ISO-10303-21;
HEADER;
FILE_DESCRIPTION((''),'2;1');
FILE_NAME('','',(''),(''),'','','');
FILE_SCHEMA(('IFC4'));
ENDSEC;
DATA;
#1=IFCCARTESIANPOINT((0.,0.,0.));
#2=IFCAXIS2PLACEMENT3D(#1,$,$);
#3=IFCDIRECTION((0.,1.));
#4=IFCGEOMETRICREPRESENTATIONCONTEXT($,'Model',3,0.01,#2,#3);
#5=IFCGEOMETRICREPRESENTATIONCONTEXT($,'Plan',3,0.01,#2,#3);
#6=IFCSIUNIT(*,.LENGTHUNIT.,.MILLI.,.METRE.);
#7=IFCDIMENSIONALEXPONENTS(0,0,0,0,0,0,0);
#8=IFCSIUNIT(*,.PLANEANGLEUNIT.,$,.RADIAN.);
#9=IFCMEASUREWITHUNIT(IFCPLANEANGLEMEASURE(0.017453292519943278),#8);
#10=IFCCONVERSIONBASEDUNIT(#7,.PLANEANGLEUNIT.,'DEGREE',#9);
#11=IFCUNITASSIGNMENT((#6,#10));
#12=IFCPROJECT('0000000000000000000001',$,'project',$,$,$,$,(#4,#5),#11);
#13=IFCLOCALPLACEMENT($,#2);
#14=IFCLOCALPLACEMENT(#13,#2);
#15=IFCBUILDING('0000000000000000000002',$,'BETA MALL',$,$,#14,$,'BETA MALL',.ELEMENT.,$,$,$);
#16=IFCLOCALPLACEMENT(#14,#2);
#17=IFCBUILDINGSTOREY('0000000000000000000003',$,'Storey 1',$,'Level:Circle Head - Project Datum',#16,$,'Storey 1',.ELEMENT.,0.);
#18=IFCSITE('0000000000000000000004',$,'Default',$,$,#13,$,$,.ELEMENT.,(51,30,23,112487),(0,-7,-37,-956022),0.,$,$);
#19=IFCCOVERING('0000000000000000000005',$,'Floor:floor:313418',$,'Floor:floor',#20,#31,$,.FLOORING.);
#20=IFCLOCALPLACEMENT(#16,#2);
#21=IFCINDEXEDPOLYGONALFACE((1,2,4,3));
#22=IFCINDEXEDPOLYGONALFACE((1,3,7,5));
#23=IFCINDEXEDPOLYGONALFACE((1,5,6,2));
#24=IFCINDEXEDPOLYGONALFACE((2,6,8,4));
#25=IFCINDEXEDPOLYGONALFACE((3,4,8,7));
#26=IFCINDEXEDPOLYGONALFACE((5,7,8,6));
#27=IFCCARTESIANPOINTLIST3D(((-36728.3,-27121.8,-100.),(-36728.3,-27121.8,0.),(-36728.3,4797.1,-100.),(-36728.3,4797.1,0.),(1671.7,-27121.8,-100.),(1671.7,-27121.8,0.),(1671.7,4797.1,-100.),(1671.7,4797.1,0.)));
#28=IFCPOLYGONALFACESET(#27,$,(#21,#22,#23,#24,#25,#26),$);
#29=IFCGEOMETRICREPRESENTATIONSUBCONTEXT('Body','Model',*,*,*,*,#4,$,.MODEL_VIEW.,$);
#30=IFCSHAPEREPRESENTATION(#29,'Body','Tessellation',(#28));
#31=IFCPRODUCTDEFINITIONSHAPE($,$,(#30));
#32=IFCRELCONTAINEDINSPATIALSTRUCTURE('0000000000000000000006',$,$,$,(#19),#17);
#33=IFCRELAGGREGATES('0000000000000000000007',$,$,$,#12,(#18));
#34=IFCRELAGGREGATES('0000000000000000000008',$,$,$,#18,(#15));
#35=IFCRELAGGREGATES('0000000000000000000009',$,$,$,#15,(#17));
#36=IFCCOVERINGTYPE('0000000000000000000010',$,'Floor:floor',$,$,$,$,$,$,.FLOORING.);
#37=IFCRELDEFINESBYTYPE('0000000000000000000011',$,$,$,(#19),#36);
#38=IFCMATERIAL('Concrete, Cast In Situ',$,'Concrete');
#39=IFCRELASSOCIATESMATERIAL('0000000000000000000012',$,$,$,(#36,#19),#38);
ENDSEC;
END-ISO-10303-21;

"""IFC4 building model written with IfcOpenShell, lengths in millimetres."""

from ifc_helpers import new_model, entity, si_unit, converted_unit, direction, frame, origin, place, context, subcontext, project, spatial, indexed_curve, outline, extrude, material, type_object, element, save


model = new_model("IFC4")

# Units and contexts
model_context = context("Model", 3, precision=0.01, world=origin(), true_north=direction((0.0, 1.0)))
plan_context = context("Plan", 3, precision=0.01, world=origin(), true_north=direction((0.0, 1.0)))
body_context = subcontext(model_context, "Body", "Model", "MODEL_VIEW")
ifc_project = project(units=[si_unit("LENGTHUNIT", "METRE", prefix="MILLI"), converted_unit("PLANEANGLEUNIT", "DEGREE", entity("IfcPlaneAngleMeasure", 0.017453292519943278), si_unit("PLANEANGLEUNIT", "RADIAN"), dimensions=[0, 0, 0, 0, 0, 0, 0])], contexts=[model_context, plan_context])

# Site, building, storey
site_placement = place(None, origin())
site = spatial("IfcSite", under=ifc_project, at=site_placement, Name="Default", CompositionType="ELEMENT", RefLatitude=(51, 30, 23, 112487), RefLongitude=(0, -7, -37, -956022), RefElevation=0.0)
building_placement = place(site_placement, origin())
building = spatial("IfcBuilding", under=site, at=building_placement, Name="BETA MALL", LongName="BETA MALL", CompositionType="ELEMENT")
storey_placement = place(building_placement, origin())
storey = spatial("IfcBuildingStorey", under=building, at=storey_placement, Name="Storey 1", ObjectType="Level:Circle Head - Project Datum", LongName="Storey 1", CompositionType="ELEMENT", Elevation=0.0)

# Covering
ifc_material_1 = material(Name="Concrete, Cast In Situ", Category="Concrete")
covering_type = type_object("IfcCoveringType", Name="Floor:floor", PredefinedType="FLOORING", material=ifc_material_1)
covering_placement = place(storey_placement, origin())
element("IfcCovering", 1, at=covering_placement, inside=storey, type_object=covering_type, material=ifc_material_1, Name="Floor:floor:313418", ObjectType="Floor:floor", PredefinedType="FLOORING", context=body_context, shape_type="SweptSolid", body=[
    extrude(outline(indexed_curve([(-15959.4, -19200.0), (15959.4, -19200.0), (15959.4, 19200.0), (-15959.4, 19200.0), (-15959.4, -19200.0)], self_intersect=False)), frame((-17528.3, -11162.4, 0.0), z_axis=(0.0, 0.0, -1.0), x_axis=(0.0, 1.0, 0.0)), (0.0, 0.0, 1.0), 100.0),
])

save(model, "model.ifc")
